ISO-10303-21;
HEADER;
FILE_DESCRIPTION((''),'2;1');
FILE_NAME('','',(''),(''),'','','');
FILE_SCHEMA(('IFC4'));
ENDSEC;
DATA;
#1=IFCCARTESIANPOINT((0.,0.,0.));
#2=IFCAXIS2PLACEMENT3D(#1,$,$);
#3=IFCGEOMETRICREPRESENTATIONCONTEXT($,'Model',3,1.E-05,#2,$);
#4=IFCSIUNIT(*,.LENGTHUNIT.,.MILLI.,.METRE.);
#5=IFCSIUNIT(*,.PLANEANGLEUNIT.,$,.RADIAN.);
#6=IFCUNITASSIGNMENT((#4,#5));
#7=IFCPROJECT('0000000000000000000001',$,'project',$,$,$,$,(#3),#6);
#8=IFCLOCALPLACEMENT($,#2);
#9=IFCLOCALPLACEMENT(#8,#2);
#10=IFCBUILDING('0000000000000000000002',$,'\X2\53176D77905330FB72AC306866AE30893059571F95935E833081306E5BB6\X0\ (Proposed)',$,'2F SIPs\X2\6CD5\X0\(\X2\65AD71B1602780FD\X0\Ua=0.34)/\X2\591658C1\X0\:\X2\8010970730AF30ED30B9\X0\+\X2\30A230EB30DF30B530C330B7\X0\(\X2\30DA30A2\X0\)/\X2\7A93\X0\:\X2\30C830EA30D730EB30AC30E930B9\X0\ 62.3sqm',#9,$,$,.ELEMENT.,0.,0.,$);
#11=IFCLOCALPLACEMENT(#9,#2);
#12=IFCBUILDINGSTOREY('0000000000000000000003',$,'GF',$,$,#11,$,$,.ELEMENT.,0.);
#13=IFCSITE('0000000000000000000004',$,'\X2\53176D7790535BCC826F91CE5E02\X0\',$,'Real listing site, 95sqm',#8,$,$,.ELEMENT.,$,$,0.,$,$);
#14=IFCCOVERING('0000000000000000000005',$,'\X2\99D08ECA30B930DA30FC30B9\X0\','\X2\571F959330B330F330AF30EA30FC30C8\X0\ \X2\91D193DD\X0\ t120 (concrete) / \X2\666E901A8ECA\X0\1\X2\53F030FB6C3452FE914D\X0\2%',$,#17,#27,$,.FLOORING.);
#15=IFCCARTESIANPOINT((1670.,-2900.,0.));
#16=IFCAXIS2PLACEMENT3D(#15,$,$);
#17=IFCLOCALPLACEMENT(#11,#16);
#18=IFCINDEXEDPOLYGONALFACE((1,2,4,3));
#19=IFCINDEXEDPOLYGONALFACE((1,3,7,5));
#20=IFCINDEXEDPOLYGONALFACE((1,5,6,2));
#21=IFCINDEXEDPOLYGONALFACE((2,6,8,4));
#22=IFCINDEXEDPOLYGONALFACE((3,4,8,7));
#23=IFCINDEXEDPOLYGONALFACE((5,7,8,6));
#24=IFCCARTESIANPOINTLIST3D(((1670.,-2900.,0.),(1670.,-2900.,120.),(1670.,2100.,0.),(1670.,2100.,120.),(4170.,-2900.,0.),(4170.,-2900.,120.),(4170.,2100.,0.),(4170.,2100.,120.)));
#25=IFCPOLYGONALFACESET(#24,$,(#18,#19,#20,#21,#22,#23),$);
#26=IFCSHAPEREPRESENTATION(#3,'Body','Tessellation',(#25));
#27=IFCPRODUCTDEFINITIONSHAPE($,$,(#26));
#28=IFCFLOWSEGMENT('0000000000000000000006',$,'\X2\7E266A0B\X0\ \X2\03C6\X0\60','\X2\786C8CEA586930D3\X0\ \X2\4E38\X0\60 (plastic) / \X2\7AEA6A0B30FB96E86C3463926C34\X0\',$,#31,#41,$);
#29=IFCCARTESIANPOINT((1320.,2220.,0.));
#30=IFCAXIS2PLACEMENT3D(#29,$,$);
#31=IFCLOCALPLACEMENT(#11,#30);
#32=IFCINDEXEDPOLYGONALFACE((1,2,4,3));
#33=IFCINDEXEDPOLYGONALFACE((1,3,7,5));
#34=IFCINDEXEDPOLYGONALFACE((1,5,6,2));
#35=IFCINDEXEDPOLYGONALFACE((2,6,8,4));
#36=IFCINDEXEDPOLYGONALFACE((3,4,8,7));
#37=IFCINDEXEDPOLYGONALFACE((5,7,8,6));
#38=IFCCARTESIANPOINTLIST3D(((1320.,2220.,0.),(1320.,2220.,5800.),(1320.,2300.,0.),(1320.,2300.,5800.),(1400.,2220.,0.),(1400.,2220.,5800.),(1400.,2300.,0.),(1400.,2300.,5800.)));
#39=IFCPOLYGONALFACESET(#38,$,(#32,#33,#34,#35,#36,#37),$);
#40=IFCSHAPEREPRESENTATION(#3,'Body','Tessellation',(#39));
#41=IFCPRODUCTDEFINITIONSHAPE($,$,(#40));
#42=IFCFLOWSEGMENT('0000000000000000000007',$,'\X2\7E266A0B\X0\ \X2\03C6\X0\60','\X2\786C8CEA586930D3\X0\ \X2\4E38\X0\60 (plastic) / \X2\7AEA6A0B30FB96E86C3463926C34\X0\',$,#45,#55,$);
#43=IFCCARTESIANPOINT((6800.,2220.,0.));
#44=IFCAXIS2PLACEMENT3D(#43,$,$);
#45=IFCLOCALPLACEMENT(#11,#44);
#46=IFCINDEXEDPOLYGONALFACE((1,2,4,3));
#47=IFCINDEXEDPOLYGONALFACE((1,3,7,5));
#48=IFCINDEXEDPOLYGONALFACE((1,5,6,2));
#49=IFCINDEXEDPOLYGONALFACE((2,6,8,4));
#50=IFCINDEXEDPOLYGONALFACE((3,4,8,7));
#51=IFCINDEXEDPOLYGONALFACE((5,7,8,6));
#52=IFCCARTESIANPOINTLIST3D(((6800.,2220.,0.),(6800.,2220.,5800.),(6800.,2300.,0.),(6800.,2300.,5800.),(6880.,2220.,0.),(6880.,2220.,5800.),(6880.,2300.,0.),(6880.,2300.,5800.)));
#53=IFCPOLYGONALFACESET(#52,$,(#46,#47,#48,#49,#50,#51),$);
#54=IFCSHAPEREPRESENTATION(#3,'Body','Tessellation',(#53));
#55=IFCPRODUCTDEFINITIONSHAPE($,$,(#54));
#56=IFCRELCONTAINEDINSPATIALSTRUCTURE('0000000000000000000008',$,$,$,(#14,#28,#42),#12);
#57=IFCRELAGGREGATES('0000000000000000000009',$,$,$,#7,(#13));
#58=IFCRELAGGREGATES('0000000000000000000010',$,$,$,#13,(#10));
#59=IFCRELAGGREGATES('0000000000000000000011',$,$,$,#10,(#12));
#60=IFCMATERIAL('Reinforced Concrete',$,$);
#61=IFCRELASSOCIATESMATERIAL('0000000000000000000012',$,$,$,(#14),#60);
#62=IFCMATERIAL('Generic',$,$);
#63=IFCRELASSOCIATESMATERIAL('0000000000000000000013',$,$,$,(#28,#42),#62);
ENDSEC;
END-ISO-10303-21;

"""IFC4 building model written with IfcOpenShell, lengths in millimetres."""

from ifc_helpers import new_model, si_unit, frame, frame_2d, origin, place, context, project, spatial, rectangle, extrude, material, element, save


model = new_model("IFC4")

# Units and contexts
model_context = context("Model", 3, precision=1e-05, world=origin())
ifc_project = project(units=[si_unit("LENGTHUNIT", "METRE", prefix="MILLI"), si_unit("PLANEANGLEUNIT", "RADIAN")], contexts=[model_context])

# Site, building, storey
site_placement = place(None, origin())
site = spatial("IfcSite", under=ifc_project, at=site_placement, Name="北海道富良野市", ObjectType="Real listing site, 95sqm", CompositionType="ELEMENT", RefElevation=0.0)
building_placement = place(site_placement, origin())
building = spatial("IfcBuilding", under=site, at=building_placement, Name="北海道・犬と暮らす土間広めの家 (Proposed)", ObjectType="2F SIPs法(断熱性能Ua=0.34)/外壁:耐震クロス+アルミサッシ(ペア)/窓:トリプルガラス 62.3sqm", CompositionType="ELEMENT", ElevationOfRefHeight=0.0, ElevationOfTerrain=0.0)
storey_placement = place(building_placement, origin())
storey = spatial("IfcBuildingStorey", under=building, at=storey_placement, Name="GF", CompositionType="ELEMENT", Elevation=0.0)

# Shared definitions
ifc_material_1 = material(Name="Reinforced Concrete")

# Covering
covering_1_placement = place(storey_placement, frame((1670.0, -2900.0, 0.0)))
element("IfcCovering", 1, at=covering_1_placement, inside=storey, material=ifc_material_1, Name="駐車スペース", Description="土間コンクリート 金鏝 t120 (concrete) / 普通車1台・水勾配2%", PredefinedType="FLOORING", context=model_context, shape_type="SweptSolid", body=[
    extrude(rectangle(XDim=2500.0, YDim=5000.0, at=frame_2d((1250.0, 2500.0))), frame((1670.0, -2900.0, 0.0)), (0.0, 0.0, 1.0), 120.0),
])

# Flow segments
ifc_material_2 = material(Name="Generic")
flow_segment_1_placement = place(storey_placement, frame((1320.0, 2220.0, 0.0)))
element("IfcFlowSegment", 2, at=flow_segment_1_placement, inside=storey, material=ifc_material_2, Name="縦樋 φ60", Description="硬質塩ビ 丸60 (plastic) / 竪樋・雨水排水", context=model_context, shape_type="SweptSolid", body=[
    extrude(rectangle(XDim=80.0, YDim=80.0, at=frame_2d((40.0, 40.0))), frame((1320.0, 2220.0, 0.0)), (0.0, 0.0, 1.0), 5800.0),
])
flow_segment_2_placement = place(storey_placement, frame((6800.0, 2220.0, 0.0)))
element("IfcFlowSegment", 3, at=flow_segment_2_placement, inside=storey, material=ifc_material_2, Name="縦樋 φ60", Description="硬質塩ビ 丸60 (plastic) / 竪樋・雨水排水", context=model_context, shape_type="SweptSolid", body=[
    extrude(rectangle(XDim=80.0, YDim=80.0, at=frame_2d((40.0, 40.0))), frame((6800.0, 2220.0, 0.0)), (0.0, 0.0, 1.0), 5800.0),
])

save(model, "model.ifc")
